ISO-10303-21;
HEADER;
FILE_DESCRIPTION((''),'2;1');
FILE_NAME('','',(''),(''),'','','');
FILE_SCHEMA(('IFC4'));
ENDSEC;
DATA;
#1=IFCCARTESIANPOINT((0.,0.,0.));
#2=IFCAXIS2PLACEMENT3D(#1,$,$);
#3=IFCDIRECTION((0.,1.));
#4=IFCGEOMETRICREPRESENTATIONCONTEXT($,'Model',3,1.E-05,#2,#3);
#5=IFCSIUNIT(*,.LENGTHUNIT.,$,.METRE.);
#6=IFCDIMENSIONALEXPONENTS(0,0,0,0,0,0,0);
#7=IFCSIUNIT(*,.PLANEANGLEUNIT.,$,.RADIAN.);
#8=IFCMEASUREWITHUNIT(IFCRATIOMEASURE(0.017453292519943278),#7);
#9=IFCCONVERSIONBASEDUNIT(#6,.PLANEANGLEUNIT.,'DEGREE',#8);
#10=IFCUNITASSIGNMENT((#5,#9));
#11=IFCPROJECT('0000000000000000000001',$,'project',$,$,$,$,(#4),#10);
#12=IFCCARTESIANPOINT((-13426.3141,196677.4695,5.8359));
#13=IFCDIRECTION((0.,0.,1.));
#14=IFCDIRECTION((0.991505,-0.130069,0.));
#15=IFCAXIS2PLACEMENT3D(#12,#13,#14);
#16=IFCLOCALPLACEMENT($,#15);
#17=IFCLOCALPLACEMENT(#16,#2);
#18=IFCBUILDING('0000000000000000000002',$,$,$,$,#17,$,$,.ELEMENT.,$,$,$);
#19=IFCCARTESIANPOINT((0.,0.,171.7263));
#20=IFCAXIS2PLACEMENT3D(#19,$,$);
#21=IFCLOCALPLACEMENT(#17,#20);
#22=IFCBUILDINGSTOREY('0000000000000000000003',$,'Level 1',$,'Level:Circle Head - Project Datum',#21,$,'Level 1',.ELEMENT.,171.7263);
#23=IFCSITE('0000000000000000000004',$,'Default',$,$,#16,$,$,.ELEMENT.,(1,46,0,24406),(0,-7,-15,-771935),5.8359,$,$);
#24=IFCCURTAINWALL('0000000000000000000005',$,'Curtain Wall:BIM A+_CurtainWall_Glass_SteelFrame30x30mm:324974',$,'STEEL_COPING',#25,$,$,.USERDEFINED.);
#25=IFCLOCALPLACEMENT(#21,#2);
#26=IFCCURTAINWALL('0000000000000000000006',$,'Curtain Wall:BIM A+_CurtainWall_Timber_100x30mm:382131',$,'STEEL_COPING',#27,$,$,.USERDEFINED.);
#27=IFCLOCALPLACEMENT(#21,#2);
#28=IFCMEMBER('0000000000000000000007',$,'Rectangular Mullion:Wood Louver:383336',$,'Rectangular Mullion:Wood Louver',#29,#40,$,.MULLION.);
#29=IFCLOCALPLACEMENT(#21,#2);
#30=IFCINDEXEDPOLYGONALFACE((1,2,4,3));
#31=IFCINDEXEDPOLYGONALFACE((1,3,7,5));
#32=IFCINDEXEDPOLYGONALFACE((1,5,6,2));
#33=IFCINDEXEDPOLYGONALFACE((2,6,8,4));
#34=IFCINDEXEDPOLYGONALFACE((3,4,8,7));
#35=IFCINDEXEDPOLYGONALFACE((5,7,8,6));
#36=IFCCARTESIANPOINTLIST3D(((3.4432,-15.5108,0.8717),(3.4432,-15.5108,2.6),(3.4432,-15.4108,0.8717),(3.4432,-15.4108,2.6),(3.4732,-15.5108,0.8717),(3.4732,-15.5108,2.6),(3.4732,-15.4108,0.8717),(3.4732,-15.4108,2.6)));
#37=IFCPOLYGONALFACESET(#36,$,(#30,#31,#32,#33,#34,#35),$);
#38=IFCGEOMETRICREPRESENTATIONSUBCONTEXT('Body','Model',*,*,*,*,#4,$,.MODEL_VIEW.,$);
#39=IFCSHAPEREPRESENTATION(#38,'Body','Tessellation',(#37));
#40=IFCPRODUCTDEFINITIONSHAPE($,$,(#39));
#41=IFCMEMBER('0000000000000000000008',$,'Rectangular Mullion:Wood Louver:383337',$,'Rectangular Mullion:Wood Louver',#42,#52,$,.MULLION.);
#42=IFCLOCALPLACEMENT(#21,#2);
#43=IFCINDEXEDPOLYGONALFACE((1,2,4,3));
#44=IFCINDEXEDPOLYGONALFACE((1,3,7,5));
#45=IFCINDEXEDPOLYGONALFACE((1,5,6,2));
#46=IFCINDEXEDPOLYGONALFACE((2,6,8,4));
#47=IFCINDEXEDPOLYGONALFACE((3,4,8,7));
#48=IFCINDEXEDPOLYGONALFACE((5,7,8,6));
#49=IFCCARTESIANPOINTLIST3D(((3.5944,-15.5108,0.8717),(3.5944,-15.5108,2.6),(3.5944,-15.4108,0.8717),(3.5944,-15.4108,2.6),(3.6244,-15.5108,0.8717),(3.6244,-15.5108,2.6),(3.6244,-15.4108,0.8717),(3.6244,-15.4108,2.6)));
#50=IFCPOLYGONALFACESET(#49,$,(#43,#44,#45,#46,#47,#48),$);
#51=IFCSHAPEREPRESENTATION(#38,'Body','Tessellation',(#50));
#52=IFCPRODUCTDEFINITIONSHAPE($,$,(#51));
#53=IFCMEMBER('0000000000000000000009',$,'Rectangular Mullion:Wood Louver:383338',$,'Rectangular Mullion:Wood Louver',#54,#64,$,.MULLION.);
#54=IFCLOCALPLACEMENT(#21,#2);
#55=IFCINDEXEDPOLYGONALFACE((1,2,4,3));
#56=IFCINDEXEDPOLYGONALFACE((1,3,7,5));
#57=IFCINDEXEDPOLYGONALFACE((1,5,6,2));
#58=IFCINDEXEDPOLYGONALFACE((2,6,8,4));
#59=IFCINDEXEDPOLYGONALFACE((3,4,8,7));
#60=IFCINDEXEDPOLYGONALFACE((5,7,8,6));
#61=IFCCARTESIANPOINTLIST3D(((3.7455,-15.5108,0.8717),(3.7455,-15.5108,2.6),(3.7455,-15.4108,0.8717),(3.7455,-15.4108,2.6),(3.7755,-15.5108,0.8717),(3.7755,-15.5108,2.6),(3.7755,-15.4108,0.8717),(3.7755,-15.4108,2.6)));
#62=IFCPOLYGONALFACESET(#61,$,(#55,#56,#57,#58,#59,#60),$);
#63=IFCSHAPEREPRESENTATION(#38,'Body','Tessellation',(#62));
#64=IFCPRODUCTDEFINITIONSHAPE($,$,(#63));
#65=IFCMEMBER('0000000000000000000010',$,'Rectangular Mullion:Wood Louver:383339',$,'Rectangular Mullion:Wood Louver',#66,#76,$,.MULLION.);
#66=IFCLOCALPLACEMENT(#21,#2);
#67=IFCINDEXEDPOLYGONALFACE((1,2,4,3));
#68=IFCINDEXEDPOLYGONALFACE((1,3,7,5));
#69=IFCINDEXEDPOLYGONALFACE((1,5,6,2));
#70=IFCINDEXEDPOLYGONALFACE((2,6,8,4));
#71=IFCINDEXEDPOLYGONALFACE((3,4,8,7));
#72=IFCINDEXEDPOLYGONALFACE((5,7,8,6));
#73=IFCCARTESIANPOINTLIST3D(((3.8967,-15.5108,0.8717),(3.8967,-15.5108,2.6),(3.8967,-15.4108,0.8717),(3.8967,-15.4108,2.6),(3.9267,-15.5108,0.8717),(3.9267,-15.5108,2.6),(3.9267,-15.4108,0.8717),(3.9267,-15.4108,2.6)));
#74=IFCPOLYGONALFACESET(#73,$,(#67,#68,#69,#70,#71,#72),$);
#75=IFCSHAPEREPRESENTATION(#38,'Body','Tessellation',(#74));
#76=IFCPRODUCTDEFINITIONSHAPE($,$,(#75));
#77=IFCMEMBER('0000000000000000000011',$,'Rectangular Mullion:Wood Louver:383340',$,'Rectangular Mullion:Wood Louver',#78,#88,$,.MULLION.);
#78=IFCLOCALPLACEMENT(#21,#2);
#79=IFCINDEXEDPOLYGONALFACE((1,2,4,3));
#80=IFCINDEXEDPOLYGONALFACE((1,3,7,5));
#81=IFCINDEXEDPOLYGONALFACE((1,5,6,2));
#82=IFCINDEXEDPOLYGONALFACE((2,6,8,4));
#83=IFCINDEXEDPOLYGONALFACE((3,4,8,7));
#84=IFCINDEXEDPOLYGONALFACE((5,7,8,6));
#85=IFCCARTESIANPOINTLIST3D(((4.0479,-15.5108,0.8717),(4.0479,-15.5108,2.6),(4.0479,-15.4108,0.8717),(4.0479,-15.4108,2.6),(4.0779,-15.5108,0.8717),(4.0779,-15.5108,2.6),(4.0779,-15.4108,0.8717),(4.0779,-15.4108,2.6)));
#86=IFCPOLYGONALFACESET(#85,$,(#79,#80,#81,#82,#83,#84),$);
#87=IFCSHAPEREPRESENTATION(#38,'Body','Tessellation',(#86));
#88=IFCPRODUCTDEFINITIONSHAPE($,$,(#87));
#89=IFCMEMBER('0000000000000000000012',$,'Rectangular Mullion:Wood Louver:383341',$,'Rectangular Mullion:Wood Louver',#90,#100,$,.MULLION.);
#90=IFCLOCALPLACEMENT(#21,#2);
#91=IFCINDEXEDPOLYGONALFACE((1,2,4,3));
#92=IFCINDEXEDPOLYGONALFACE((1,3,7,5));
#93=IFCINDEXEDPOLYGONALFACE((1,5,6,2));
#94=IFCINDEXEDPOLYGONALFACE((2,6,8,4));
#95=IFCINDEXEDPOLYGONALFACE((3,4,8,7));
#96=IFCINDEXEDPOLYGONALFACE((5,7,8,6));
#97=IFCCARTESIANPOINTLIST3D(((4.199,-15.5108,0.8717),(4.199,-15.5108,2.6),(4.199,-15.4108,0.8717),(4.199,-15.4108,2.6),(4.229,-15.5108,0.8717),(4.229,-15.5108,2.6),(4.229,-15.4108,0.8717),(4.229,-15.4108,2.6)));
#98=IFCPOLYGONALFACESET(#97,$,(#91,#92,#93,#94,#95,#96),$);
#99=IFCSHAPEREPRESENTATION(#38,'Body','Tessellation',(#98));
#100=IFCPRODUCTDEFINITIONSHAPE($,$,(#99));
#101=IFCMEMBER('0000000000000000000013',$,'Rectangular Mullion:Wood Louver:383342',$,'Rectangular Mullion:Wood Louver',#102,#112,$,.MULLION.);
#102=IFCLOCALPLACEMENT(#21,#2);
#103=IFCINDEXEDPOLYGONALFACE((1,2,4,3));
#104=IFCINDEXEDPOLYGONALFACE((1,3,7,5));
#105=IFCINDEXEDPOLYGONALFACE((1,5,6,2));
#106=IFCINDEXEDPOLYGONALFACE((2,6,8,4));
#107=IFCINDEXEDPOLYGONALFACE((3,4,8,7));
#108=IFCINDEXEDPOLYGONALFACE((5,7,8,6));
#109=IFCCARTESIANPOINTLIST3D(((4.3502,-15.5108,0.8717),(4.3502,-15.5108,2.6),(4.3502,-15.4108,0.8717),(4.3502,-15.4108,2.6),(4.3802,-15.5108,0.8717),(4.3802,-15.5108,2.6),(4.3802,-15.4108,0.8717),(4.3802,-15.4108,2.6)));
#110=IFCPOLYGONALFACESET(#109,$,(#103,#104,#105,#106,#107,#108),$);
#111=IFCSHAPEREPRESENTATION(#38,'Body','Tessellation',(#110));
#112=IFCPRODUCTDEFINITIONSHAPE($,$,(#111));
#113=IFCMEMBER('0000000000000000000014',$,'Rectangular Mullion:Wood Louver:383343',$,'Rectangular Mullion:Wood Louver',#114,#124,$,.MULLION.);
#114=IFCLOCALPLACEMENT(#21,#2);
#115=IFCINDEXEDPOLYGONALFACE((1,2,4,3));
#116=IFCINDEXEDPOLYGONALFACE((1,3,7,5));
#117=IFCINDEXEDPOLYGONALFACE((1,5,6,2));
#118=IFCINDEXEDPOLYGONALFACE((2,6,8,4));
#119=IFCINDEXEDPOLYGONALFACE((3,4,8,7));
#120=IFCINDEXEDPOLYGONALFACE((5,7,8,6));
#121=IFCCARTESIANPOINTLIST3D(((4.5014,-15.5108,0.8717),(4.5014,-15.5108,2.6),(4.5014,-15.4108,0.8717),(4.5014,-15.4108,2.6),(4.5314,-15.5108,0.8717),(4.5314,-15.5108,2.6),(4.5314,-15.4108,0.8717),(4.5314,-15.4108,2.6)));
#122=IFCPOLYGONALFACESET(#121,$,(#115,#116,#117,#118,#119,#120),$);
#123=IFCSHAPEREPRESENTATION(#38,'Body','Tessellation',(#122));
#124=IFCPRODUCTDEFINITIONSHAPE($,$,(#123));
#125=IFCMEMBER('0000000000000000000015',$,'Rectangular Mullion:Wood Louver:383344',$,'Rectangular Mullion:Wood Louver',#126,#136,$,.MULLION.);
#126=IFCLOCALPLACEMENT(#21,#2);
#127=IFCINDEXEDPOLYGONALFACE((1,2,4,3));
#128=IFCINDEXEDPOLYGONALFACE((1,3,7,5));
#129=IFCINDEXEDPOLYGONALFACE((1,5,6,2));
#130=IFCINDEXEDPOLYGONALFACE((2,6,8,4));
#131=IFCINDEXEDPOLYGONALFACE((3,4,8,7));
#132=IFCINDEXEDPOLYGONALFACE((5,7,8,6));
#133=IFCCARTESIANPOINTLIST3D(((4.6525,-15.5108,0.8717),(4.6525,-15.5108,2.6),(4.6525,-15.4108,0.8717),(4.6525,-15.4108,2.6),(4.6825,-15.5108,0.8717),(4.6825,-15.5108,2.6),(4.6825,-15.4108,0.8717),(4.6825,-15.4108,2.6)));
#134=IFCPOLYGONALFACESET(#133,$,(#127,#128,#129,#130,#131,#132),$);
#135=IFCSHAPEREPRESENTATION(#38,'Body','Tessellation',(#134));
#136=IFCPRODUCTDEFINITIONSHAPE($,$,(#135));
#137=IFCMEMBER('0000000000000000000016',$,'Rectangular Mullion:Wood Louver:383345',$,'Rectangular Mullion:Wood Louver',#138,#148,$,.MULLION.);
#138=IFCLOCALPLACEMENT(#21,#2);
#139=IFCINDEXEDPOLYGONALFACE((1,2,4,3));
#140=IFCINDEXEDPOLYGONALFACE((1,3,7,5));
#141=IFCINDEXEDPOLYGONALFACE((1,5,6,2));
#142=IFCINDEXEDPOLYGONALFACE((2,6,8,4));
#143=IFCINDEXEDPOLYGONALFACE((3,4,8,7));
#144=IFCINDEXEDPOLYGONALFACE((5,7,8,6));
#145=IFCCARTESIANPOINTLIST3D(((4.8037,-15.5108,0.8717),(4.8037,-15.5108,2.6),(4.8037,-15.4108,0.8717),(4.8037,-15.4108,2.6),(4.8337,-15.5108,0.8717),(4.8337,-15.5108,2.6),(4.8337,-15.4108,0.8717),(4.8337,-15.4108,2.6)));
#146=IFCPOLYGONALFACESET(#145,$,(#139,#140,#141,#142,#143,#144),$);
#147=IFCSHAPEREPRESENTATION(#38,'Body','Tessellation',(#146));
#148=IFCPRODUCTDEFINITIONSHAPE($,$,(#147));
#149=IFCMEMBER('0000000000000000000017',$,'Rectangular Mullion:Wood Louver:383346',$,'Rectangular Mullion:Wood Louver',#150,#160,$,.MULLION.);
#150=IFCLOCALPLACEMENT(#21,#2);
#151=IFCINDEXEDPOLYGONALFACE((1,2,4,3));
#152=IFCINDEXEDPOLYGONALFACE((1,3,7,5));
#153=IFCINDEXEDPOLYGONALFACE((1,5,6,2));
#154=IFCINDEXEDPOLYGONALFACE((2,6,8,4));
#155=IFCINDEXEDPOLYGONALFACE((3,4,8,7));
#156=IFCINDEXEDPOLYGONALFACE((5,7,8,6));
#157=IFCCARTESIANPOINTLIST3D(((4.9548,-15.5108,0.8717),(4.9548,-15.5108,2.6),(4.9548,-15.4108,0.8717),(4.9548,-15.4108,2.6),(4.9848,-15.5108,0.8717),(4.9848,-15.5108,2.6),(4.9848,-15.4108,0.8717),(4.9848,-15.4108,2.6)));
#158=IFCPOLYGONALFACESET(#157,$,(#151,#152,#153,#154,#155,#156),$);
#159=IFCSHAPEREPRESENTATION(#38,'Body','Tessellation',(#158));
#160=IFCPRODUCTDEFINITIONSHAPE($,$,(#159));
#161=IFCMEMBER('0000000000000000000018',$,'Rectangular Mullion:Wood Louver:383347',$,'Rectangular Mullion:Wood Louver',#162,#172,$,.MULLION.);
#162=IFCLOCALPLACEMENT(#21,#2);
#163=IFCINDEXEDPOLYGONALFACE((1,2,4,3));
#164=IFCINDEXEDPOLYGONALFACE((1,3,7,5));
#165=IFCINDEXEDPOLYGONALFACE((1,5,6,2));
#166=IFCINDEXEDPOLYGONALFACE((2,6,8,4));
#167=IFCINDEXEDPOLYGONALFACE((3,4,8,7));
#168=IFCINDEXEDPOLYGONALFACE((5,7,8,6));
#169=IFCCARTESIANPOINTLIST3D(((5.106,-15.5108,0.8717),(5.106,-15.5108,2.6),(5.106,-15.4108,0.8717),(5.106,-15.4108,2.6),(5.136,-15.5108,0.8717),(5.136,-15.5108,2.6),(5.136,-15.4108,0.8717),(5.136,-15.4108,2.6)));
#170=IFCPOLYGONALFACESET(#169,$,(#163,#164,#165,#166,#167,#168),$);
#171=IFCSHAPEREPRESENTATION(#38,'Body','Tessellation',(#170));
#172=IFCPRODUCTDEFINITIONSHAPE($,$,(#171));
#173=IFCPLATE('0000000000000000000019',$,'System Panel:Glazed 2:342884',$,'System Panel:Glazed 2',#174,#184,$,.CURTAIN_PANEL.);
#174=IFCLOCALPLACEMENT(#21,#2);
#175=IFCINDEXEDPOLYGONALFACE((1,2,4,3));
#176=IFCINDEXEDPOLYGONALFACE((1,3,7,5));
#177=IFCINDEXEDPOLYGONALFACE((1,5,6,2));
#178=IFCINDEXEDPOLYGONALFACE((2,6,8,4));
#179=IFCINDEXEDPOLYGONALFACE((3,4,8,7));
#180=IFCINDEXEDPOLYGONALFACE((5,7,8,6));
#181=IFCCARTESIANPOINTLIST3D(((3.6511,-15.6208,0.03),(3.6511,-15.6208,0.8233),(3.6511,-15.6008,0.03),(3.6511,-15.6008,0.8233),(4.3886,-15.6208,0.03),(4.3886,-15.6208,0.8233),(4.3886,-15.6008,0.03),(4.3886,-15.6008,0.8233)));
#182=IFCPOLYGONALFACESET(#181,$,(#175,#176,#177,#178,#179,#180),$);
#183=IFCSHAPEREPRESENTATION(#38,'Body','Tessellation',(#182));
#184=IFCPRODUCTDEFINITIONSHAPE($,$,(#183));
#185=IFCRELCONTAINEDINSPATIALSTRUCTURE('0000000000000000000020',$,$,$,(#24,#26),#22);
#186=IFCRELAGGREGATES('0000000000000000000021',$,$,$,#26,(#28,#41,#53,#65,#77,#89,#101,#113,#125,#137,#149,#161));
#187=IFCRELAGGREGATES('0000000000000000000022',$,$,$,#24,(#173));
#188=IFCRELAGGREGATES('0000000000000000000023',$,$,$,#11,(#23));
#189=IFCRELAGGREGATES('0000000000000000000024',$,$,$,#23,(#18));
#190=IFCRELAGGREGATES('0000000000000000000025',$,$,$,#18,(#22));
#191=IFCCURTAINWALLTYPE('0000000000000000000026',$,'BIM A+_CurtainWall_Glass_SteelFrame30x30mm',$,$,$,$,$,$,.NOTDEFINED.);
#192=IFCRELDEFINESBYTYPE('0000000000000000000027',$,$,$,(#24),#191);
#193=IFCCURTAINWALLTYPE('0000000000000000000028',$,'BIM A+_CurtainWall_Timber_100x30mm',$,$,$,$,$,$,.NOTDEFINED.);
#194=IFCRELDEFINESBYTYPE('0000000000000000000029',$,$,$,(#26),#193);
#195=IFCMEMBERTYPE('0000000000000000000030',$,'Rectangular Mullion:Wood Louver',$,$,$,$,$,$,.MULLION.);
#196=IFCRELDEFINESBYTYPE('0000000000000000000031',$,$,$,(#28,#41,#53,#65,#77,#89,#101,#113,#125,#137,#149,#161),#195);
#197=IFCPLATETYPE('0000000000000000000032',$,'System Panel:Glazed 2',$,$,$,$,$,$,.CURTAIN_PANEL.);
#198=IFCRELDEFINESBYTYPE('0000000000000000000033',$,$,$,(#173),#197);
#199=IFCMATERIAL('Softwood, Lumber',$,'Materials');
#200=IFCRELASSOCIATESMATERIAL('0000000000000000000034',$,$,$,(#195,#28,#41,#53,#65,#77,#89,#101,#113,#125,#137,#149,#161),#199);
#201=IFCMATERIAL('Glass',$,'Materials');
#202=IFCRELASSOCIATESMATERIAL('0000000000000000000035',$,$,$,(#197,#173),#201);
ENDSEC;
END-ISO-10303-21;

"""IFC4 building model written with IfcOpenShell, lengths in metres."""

from ifc_helpers import new_model, entity, si_unit, converted_unit, direction, frame, origin, place, context, subcontext, project, spatial, indexed_curve, outline, extrude, source, transform, mapped, material, type_object, type_shapes, element, aggregate, save


model = new_model("IFC4")

# Units and contexts
model_context = context("Model", 3, precision=1e-05, world=origin(), true_north=direction((0.0, 1.0)))
body_context = subcontext(model_context, "Body", "Model", "MODEL_VIEW")
ifc_project = project(units=[si_unit("LENGTHUNIT", "METRE"), converted_unit("PLANEANGLEUNIT", "DEGREE", entity("IfcRatioMeasure", 0.017453292519943278), si_unit("PLANEANGLEUNIT", "RADIAN"), dimensions=[0, 0, 0, 0, 0, 0, 0])], contexts=[model_context])

# Site, building, storey
site_placement = place(None, frame((-13426.3141, 196677.4695, 5.8359), z_axis=(0.0, 0.0, 1.0), x_axis=(0.991505, -0.130069, 0.0)))
site = spatial("IfcSite", under=ifc_project, at=site_placement, Name="Default", CompositionType="ELEMENT", RefLatitude=(1, 46, 0, 24406), RefLongitude=(0, -7, -15, -771935), RefElevation=5.8359)
building_placement = place(site_placement, origin())
building = spatial("IfcBuilding", under=site, at=building_placement, CompositionType="ELEMENT")
storey_placement = place(building_placement, frame((0.0, 0.0, 171.7263)))
storey = spatial("IfcBuildingStorey", under=building, at=storey_placement, Name="Level 1", ObjectType="Level:Circle Head - Project Datum", LongName="Level 1", CompositionType="ELEMENT", Elevation=171.7263)

# Curtain walls, members
curtain_wall_type_1 = type_object("IfcCurtainWallType", Name="BIM A+_CurtainWall_Glass_SteelFrame30x30mm", PredefinedType="NOTDEFINED")
curtain_wall_1_placement = place(storey_placement, frame((0.0, 0.0, -171.7263)))
curtain_wall_1 = element("IfcCurtainWall", 1, at=curtain_wall_1_placement, inside=storey, type_object=curtain_wall_type_1, Name="Curtain Wall:BIM A+_CurtainWall_Glass_SteelFrame30x30mm:324974", ObjectType="STEEL_COPING", PredefinedType="USERDEFINED")
curtain_wall_type_2 = type_object("IfcCurtainWallType", Name="BIM A+_CurtainWall_Timber_100x30mm", PredefinedType="NOTDEFINED")
curtain_wall_2_placement = place(storey_placement, frame((0.0, 0.0, -171.7263)))
curtain_wall_2 = element("IfcCurtainWall", 2, at=curtain_wall_2_placement, inside=storey, type_object=curtain_wall_type_2, Name="Curtain Wall:BIM A+_CurtainWall_Timber_100x30mm:382131", ObjectType="STEEL_COPING", PredefinedType="USERDEFINED")
ifc_material_1 = material(Name="Softwood, Lumber", Category="Materials")
member_type_1 = type_object("IfcMemberType", Name="Rectangular Mullion:Wood Louver", PredefinedType="MULLION", material=ifc_material_1)
shared_shape_1 = source(origin(), body_context, "Body", "SweptSolid", [
    extrude(outline(indexed_curve([(-0.05, -0.015), (0.05, -0.015), (0.05, 0.015), (-0.05, 0.015), (-0.05, -0.015)], self_intersect=False)), frame((0.0, -0.035, -1.7283), z_axis=(0.0, 0.0, 1.0), x_axis=(0.0, -1.0, 0.0)), (0.0, 0.0, 1.0), 1.7283),
])
type_shapes(member_type_1, [shared_shape_1])
member_1_placement = place(curtain_wall_2_placement, frame((3.4582, -15.4958, 172.598), z_axis=(0.0, 0.0, -1.0), x_axis=(1.0, 0.0, 0.0)))
member_1 = element("IfcMember", 3, at=member_1_placement, type_object=member_type_1, material=ifc_material_1, Name="Rectangular Mullion:Wood Louver:383336", ObjectType="Rectangular Mullion:Wood Louver", PredefinedType="MULLION", context=body_context, shape_type="MappedRepresentation", body=[
    mapped(shared_shape_1, transform((0.0, 0.0, 0.0), scale=1.0)),
])
member_2_placement = place(curtain_wall_2_placement, frame((3.6094, -15.4958, 172.598), z_axis=(0.0, 0.0, -1.0), x_axis=(1.0, 0.0, 0.0)))
member_2 = element("IfcMember", 4, at=member_2_placement, type_object=member_type_1, material=ifc_material_1, Name="Rectangular Mullion:Wood Louver:383337", ObjectType="Rectangular Mullion:Wood Louver", PredefinedType="MULLION", context=body_context, shape_type="MappedRepresentation", body=[
    mapped(shared_shape_1, transform((0.0, 0.0, 0.0), scale=1.0)),
])
member_3_placement = place(curtain_wall_2_placement, frame((3.7605, -15.4958, 172.598), z_axis=(0.0, 0.0, -1.0), x_axis=(1.0, 0.0, 0.0)))
member_3 = element("IfcMember", 5, at=member_3_placement, type_object=member_type_1, material=ifc_material_1, Name="Rectangular Mullion:Wood Louver:383338", ObjectType="Rectangular Mullion:Wood Louver", PredefinedType="MULLION", context=body_context, shape_type="MappedRepresentation", body=[
    mapped(shared_shape_1, transform((0.0, 0.0, 0.0), scale=1.0)),
])
member_4_placement = place(curtain_wall_2_placement, frame((3.9117, -15.4958, 172.598), z_axis=(0.0, 0.0, -1.0), x_axis=(1.0, 0.0, 0.0)))
member_4 = element("IfcMember", 6, at=member_4_placement, type_object=member_type_1, material=ifc_material_1, Name="Rectangular Mullion:Wood Louver:383339", ObjectType="Rectangular Mullion:Wood Louver", PredefinedType="MULLION", context=body_context, shape_type="MappedRepresentation", body=[
    mapped(shared_shape_1, transform((0.0, 0.0, 0.0), scale=1.0)),
])
member_5_placement = place(curtain_wall_2_placement, frame((4.0629, -15.4958, 172.598), z_axis=(0.0, 0.0, -1.0), x_axis=(1.0, 0.0, 0.0)))
member_5 = element("IfcMember", 7, at=member_5_placement, type_object=member_type_1, material=ifc_material_1, Name="Rectangular Mullion:Wood Louver:383340", ObjectType="Rectangular Mullion:Wood Louver", PredefinedType="MULLION", context=body_context, shape_type="MappedRepresentation", body=[
    mapped(shared_shape_1, transform((0.0, 0.0, 0.0), scale=1.0)),
])
member_6_placement = place(curtain_wall_2_placement, frame((4.214, -15.4958, 172.598), z_axis=(0.0, 0.0, -1.0), x_axis=(1.0, 0.0, 0.0)))
member_6 = element("IfcMember", 8, at=member_6_placement, type_object=member_type_1, material=ifc_material_1, Name="Rectangular Mullion:Wood Louver:383341", ObjectType="Rectangular Mullion:Wood Louver", PredefinedType="MULLION", context=body_context, shape_type="MappedRepresentation", body=[
    mapped(shared_shape_1, transform((0.0, 0.0, 0.0), scale=1.0)),
])
member_7_placement = place(curtain_wall_2_placement, frame((4.3652, -15.4958, 172.598), z_axis=(0.0, 0.0, -1.0), x_axis=(1.0, 0.0, 0.0)))
member_7 = element("IfcMember", 9, at=member_7_placement, type_object=member_type_1, material=ifc_material_1, Name="Rectangular Mullion:Wood Louver:383342", ObjectType="Rectangular Mullion:Wood Louver", PredefinedType="MULLION", context=body_context, shape_type="MappedRepresentation", body=[
    mapped(shared_shape_1, transform((0.0, 0.0, 0.0), scale=1.0)),
])
member_8_placement = place(curtain_wall_2_placement, frame((4.5164, -15.4958, 172.598), z_axis=(0.0, 0.0, -1.0), x_axis=(1.0, 0.0, 0.0)))
member_8 = element("IfcMember", 10, at=member_8_placement, type_object=member_type_1, material=ifc_material_1, Name="Rectangular Mullion:Wood Louver:383343", ObjectType="Rectangular Mullion:Wood Louver", PredefinedType="MULLION", context=body_context, shape_type="MappedRepresentation", body=[
    mapped(shared_shape_1, transform((0.0, 0.0, 0.0), scale=1.0)),
])
member_9_placement = place(curtain_wall_2_placement, frame((4.6675, -15.4958, 172.598), z_axis=(0.0, 0.0, -1.0), x_axis=(1.0, 0.0, 0.0)))
member_9 = element("IfcMember", 11, at=member_9_placement, type_object=member_type_1, material=ifc_material_1, Name="Rectangular Mullion:Wood Louver:383344", ObjectType="Rectangular Mullion:Wood Louver", PredefinedType="MULLION", context=body_context, shape_type="MappedRepresentation", body=[
    mapped(shared_shape_1, transform((0.0, 0.0, 0.0), scale=1.0)),
])
member_10_placement = place(curtain_wall_2_placement, frame((4.8187, -15.4958, 172.598), z_axis=(0.0, 0.0, -1.0), x_axis=(1.0, 0.0, 0.0)))
member_10 = element("IfcMember", 12, at=member_10_placement, type_object=member_type_1, material=ifc_material_1, Name="Rectangular Mullion:Wood Louver:383345", ObjectType="Rectangular Mullion:Wood Louver", PredefinedType="MULLION", context=body_context, shape_type="MappedRepresentation", body=[
    mapped(shared_shape_1, transform((0.0, 0.0, 0.0), scale=1.0)),
])
member_11_placement = place(curtain_wall_2_placement, frame((4.9698, -15.4958, 172.598), z_axis=(0.0, 0.0, -1.0), x_axis=(1.0, 0.0, 0.0)))
member_11 = element("IfcMember", 13, at=member_11_placement, type_object=member_type_1, material=ifc_material_1, Name="Rectangular Mullion:Wood Louver:383346", ObjectType="Rectangular Mullion:Wood Louver", PredefinedType="MULLION", context=body_context, shape_type="MappedRepresentation", body=[
    mapped(shared_shape_1, transform((0.0, 0.0, 0.0), scale=1.0)),
])
member_12_placement = place(curtain_wall_2_placement, frame((5.121, -15.4958, 172.598), z_axis=(0.0, 0.0, -1.0), x_axis=(1.0, 0.0, 0.0)))
member_12 = element("IfcMember", 14, at=member_12_placement, type_object=member_type_1, material=ifc_material_1, Name="Rectangular Mullion:Wood Louver:383347", ObjectType="Rectangular Mullion:Wood Louver", PredefinedType="MULLION", context=body_context, shape_type="MappedRepresentation", body=[
    mapped(shared_shape_1, transform((0.0, 0.0, 0.0), scale=1.0)),
])
aggregate(curtain_wall_2, [member_1, member_2, member_3, member_4, member_5, member_6, member_7, member_8, member_9, member_10, member_11, member_12])

# Plate
ifc_material_2 = material(Name="Glass", Category="Materials")
plate_type = type_object("IfcPlateType", Name="System Panel:Glazed 2", PredefinedType="CURTAIN_PANEL", material=ifc_material_2)
shared_shape_2 = source(origin(), body_context, "Body", "SweptSolid", [
    extrude(outline(indexed_curve([(-0.01, -0.3688), (0.01, -0.3688), (0.01, 0.3688), (-0.01, 0.3688), (-0.01, -0.3688)], self_intersect=False)), frame((0.0, 0.0, 0.0), z_axis=(0.0, 0.0, 1.0), x_axis=(0.0, 1.0, 0.0)), (0.0, 0.0, 1.0), 0.7933),
])
type_shapes(plate_type, [shared_shape_2])
plate_1_placement = place(curtain_wall_1_placement, frame((4.0198, -15.6108, 171.7563), z_axis=(0.0, 0.0, 1.0), x_axis=(-1.0, 0.0, 0.0)))
plate_1 = element("IfcPlate", 15, at=plate_1_placement, type_object=plate_type, material=ifc_material_2, Name="System Panel:Glazed 2:342884", ObjectType="System Panel:Glazed 2", PredefinedType="CURTAIN_PANEL", context=body_context, shape_type="MappedRepresentation", body=[
    mapped(shared_shape_2, transform((0.0, 0.0, 0.0), scale=1.0)),
])
aggregate(curtain_wall_1, [plate_1])

save(model, "model.ifc")
